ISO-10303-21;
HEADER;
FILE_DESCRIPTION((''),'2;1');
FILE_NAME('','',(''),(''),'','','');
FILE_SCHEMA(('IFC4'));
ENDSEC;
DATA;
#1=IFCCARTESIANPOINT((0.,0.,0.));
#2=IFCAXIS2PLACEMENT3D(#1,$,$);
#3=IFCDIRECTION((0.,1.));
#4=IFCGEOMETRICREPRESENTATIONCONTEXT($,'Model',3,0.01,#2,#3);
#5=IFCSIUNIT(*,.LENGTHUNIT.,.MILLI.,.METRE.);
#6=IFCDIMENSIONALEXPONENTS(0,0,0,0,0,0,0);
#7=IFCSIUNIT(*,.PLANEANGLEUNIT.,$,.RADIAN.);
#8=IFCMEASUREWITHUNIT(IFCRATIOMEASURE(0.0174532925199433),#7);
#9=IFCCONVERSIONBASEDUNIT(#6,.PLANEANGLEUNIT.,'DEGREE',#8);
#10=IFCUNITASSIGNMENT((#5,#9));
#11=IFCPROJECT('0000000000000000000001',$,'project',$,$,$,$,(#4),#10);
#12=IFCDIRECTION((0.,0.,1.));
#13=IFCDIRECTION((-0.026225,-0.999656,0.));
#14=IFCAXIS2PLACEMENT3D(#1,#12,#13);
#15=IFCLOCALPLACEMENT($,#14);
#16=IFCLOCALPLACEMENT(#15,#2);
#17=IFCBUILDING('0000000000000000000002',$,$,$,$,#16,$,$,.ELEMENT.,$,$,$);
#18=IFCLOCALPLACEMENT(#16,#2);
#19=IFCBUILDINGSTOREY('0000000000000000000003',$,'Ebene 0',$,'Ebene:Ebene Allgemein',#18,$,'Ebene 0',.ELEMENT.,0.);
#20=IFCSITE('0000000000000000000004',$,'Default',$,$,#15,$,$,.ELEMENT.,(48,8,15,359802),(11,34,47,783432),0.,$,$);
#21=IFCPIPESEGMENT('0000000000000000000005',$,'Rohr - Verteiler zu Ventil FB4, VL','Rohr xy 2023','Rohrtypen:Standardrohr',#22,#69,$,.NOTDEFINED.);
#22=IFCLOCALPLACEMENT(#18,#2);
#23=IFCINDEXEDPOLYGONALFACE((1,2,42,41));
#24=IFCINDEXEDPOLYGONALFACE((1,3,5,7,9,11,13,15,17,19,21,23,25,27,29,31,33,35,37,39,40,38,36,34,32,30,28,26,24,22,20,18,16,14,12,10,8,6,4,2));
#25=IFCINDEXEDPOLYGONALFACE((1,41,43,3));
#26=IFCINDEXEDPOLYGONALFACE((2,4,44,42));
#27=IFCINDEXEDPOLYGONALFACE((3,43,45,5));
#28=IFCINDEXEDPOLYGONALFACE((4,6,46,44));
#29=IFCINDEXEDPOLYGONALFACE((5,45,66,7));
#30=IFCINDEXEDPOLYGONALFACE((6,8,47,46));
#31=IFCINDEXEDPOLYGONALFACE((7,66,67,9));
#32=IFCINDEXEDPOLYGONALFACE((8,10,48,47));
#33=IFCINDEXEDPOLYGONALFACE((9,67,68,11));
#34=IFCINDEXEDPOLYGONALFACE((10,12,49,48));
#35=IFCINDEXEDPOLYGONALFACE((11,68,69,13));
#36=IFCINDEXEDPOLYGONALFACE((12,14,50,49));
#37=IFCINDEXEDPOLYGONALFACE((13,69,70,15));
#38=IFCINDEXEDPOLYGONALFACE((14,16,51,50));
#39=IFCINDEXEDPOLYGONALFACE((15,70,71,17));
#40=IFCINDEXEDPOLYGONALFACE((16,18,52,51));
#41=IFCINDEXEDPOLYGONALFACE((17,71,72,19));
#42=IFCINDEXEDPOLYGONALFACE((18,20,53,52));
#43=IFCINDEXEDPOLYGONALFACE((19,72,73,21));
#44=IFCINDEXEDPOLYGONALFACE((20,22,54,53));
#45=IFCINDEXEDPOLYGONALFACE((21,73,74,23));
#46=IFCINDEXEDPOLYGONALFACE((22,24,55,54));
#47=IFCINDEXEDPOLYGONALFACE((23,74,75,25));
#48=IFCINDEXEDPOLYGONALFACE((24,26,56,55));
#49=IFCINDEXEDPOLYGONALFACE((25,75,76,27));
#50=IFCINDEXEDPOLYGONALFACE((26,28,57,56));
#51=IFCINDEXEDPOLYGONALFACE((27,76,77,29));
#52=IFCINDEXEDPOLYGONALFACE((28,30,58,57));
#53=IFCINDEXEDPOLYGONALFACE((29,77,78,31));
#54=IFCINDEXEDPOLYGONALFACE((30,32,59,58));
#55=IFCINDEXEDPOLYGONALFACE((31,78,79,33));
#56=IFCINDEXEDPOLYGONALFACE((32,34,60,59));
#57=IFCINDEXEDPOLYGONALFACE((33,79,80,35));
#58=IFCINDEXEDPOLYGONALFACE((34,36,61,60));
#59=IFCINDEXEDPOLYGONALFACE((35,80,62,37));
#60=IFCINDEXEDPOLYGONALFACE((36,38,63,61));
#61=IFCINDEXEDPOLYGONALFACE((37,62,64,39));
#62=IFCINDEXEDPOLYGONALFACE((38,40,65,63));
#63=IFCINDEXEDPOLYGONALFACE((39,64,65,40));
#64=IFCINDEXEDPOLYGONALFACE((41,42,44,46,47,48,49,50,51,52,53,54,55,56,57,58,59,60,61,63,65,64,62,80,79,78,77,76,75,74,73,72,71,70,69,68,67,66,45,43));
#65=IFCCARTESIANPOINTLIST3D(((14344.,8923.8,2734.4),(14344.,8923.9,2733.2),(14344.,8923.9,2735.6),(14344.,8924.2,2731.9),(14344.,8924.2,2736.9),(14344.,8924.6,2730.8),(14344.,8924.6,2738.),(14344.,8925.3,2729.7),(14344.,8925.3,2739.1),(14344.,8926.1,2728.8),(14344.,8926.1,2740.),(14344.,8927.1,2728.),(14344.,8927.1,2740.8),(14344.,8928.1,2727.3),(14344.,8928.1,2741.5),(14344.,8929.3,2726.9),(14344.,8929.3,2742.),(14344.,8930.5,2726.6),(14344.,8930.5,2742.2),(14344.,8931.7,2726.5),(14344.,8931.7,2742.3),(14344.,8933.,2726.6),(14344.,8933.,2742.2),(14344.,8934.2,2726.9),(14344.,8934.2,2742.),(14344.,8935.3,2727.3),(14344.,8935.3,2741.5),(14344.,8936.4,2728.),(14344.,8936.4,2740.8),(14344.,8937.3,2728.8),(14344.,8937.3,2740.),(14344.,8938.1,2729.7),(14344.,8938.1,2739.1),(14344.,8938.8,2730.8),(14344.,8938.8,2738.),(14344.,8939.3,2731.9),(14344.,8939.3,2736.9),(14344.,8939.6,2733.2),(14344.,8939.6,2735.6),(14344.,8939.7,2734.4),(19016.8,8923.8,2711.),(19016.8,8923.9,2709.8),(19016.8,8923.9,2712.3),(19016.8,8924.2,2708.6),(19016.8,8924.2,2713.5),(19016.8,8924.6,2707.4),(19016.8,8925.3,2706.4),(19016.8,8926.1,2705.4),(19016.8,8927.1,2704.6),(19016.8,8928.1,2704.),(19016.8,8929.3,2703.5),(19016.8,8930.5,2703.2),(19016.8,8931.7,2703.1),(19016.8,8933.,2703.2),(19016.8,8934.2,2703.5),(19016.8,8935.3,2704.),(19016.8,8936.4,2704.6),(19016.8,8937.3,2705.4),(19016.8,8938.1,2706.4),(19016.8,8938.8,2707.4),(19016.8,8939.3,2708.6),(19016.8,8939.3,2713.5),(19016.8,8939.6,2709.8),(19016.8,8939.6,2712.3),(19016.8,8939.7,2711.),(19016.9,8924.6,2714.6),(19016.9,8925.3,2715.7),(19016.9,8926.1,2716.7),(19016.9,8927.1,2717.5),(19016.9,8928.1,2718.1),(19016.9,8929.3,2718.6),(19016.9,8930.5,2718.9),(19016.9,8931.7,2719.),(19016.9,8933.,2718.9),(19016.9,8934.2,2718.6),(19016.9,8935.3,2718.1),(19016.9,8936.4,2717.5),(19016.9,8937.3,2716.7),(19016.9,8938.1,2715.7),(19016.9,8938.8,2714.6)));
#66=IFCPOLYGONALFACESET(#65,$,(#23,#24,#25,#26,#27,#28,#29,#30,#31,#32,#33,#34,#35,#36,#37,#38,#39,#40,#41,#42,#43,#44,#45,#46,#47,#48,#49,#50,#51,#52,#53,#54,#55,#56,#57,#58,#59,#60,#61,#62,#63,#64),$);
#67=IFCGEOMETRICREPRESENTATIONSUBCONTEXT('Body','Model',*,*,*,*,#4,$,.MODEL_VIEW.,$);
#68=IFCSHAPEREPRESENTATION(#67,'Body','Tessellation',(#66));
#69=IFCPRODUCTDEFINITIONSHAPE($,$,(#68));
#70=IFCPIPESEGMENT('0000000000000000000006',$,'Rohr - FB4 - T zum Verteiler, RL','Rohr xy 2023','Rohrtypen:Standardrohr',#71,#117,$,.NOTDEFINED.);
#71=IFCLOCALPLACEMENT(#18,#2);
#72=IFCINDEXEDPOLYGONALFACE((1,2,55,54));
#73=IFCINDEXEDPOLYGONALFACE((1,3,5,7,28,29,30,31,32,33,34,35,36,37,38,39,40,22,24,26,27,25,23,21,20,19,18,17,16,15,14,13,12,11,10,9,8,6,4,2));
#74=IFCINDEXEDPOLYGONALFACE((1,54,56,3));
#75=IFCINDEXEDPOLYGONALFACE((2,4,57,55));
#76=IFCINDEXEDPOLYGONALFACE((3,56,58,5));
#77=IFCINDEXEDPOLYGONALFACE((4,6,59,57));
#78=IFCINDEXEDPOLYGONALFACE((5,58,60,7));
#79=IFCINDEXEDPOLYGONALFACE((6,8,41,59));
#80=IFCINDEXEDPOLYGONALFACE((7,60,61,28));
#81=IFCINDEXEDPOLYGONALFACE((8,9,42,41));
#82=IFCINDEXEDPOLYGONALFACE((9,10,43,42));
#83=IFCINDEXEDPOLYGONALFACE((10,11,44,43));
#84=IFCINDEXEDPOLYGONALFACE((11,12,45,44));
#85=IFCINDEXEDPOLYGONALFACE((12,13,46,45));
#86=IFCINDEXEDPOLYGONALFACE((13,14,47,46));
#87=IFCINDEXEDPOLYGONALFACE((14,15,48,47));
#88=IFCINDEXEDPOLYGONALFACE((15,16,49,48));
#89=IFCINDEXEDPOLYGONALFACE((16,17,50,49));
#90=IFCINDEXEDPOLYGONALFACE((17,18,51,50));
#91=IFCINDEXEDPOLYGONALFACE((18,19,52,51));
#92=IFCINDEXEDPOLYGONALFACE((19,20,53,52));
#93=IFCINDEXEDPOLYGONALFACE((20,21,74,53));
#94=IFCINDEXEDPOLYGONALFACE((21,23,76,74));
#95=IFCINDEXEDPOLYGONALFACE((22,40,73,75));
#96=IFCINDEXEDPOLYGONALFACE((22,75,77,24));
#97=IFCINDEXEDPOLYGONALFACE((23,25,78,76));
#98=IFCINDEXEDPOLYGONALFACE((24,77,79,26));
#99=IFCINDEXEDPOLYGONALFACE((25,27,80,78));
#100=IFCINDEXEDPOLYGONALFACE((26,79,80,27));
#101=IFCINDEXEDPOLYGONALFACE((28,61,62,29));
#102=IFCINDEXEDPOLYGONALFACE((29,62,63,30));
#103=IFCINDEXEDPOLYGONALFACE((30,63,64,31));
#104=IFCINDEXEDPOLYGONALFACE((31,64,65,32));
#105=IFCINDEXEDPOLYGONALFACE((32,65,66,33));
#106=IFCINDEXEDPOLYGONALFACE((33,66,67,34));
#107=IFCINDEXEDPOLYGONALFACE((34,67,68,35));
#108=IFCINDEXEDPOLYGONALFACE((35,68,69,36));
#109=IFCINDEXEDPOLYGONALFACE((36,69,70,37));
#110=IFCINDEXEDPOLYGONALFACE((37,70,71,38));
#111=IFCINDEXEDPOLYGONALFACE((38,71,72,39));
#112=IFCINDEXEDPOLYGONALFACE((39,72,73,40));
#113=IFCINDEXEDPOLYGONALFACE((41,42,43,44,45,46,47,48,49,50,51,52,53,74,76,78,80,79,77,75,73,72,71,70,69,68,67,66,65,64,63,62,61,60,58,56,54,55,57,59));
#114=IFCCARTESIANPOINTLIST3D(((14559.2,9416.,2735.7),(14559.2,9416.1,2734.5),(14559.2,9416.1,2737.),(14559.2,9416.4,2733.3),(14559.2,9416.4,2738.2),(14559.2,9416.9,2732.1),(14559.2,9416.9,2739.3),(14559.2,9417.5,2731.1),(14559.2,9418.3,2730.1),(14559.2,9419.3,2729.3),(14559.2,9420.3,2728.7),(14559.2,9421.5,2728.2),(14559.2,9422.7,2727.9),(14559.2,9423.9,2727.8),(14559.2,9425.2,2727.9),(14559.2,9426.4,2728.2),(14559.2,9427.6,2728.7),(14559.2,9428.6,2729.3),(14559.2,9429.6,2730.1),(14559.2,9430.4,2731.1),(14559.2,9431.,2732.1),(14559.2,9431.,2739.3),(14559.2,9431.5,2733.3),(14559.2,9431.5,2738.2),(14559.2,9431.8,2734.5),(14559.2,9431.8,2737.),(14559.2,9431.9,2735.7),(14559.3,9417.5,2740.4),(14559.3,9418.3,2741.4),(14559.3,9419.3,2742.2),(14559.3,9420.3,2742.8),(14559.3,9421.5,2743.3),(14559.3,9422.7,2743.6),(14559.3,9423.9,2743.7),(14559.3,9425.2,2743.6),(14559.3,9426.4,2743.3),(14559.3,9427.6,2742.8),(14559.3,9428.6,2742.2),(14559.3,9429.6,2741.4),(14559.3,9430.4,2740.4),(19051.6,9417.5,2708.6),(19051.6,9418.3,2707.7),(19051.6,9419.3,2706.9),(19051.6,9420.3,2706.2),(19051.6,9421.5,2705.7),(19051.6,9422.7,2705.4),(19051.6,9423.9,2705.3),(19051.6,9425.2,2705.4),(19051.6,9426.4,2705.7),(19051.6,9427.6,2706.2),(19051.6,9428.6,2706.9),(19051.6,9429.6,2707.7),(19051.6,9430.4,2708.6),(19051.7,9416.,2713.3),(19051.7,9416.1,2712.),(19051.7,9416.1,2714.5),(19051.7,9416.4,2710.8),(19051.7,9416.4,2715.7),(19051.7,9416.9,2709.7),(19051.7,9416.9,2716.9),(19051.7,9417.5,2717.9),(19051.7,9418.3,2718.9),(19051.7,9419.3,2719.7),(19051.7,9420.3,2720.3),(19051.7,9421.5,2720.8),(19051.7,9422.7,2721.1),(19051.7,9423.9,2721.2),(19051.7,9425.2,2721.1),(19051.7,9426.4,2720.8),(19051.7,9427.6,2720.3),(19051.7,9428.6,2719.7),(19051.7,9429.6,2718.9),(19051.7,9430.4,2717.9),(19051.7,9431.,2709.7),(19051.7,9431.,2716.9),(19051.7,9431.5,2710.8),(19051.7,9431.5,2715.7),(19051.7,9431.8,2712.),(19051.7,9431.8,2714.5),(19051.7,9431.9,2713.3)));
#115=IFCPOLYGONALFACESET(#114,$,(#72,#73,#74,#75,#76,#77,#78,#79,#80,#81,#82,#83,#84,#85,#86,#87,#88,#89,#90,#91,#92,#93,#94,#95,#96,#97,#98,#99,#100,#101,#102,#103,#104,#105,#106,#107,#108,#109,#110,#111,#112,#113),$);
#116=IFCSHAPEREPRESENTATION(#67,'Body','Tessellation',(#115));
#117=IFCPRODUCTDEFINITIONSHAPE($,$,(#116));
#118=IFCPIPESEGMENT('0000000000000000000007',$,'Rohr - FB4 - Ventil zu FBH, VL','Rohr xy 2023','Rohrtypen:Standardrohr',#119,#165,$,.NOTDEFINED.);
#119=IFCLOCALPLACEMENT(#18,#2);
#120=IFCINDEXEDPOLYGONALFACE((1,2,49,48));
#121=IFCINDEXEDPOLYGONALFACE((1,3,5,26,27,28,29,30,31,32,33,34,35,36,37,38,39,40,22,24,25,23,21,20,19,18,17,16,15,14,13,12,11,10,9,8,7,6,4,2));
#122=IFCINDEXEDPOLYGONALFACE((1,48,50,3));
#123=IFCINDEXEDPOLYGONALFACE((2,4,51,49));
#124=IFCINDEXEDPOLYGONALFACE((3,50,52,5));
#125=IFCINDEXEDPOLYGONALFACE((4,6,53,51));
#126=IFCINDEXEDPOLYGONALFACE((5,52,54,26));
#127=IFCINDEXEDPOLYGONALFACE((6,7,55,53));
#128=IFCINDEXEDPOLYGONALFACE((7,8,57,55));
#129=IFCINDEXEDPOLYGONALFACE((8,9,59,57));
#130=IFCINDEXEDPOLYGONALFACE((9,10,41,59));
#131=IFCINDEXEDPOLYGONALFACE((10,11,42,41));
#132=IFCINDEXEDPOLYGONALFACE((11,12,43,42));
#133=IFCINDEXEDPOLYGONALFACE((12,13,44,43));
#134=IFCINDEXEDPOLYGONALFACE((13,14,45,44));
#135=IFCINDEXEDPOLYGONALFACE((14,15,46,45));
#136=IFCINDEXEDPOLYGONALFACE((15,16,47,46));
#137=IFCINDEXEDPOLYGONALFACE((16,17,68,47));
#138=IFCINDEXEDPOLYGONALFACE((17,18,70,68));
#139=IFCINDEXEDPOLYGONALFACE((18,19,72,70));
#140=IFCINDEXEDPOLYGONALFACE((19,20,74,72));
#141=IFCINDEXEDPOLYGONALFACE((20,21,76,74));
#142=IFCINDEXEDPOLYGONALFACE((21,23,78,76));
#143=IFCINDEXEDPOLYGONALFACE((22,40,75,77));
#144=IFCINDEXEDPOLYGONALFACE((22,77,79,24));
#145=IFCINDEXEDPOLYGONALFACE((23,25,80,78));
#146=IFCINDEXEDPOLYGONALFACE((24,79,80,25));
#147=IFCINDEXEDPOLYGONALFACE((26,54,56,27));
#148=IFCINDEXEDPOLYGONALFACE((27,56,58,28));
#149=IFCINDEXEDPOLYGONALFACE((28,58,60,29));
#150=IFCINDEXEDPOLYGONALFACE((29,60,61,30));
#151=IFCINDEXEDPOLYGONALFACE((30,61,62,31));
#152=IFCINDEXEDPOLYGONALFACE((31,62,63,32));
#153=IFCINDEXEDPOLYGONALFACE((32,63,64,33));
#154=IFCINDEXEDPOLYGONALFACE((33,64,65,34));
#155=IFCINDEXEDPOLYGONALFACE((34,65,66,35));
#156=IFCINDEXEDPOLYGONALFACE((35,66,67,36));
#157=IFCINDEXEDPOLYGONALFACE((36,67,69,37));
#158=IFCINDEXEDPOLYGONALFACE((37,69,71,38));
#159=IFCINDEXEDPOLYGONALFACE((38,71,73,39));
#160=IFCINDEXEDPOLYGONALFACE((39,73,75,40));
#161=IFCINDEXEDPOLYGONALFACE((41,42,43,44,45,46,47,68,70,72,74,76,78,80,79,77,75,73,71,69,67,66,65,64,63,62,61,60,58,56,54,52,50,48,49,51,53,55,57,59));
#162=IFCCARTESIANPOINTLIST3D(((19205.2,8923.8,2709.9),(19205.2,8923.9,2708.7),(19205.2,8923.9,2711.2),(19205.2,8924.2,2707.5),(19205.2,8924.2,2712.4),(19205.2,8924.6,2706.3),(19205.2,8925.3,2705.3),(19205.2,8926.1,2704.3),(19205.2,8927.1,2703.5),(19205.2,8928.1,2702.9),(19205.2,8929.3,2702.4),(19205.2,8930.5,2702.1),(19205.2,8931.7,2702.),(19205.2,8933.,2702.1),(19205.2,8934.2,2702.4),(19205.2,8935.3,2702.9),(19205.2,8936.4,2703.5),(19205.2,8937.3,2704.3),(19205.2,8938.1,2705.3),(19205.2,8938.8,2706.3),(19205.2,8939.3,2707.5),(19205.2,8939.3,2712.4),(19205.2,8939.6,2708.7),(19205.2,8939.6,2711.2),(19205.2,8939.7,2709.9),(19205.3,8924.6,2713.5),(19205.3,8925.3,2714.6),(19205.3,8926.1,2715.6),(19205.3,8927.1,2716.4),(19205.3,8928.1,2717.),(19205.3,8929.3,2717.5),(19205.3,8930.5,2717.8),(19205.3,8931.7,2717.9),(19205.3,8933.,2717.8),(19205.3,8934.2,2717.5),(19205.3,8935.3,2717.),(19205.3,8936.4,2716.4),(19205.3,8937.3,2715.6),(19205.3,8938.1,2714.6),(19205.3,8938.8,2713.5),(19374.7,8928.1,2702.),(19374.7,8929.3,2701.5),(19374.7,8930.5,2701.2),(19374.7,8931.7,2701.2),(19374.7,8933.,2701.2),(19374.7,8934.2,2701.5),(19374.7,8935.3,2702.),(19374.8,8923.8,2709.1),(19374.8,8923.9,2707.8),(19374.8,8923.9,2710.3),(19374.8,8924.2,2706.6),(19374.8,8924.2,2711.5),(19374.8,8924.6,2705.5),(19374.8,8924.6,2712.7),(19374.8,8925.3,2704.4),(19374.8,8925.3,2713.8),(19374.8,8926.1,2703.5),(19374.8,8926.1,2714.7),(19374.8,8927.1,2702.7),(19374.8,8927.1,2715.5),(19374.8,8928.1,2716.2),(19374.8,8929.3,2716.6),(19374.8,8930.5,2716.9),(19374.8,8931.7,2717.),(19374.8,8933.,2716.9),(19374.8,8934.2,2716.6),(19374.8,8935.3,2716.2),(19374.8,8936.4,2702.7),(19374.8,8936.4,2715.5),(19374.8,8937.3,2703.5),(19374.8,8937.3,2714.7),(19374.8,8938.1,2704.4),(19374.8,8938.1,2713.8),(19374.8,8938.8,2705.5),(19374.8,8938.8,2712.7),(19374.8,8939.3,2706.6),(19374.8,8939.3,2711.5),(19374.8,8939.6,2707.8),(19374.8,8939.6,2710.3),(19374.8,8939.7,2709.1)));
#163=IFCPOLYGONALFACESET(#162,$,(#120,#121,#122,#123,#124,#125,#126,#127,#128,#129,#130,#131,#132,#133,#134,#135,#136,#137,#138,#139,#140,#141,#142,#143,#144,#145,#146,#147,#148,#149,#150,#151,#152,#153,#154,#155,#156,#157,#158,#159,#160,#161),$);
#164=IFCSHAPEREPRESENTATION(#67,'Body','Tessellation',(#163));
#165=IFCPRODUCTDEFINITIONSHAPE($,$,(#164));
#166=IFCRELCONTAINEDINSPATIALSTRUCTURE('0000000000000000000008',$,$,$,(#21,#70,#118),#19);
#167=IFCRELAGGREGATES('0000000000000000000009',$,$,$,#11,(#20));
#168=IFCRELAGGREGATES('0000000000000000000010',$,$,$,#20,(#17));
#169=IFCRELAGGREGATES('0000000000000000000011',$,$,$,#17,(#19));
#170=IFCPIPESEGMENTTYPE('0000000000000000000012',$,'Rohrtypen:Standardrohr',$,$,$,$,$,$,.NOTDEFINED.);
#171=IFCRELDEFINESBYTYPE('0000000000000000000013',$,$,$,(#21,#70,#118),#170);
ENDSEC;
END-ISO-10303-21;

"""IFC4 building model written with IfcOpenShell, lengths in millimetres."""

from ifc_helpers import new_model, entity, si_unit, converted_unit, direction, frame, origin, place, context, subcontext, project, spatial, indexed_curve, outline, extrude, type_object, element, save


model = new_model("IFC4")

# Units and contexts
model_context = context("Model", 3, precision=0.01, world=origin(), true_north=direction((0.0, 1.0)))
body_context = subcontext(model_context, "Body", "Model", "MODEL_VIEW")
ifc_project = project(units=[si_unit("LENGTHUNIT", "METRE", prefix="MILLI"), converted_unit("PLANEANGLEUNIT", "DEGREE", entity("IfcRatioMeasure", 0.0174532925199433), si_unit("PLANEANGLEUNIT", "RADIAN"), dimensions=[0, 0, 0, 0, 0, 0, 0])], contexts=[model_context])

# Site, building, storey
site_placement = place(None, frame((0.0, 0.0, 0.0), z_axis=(0.0, 0.0, 1.0), x_axis=(-0.026225, -0.999656, 0.0)))
site = spatial("IfcSite", under=ifc_project, at=site_placement, Name="Default", CompositionType="ELEMENT", RefLatitude=(48, 8, 15, 359802), RefLongitude=(11, 34, 47, 783432), RefElevation=0.0)
building_placement = place(site_placement, origin())
building = spatial("IfcBuilding", under=site, at=building_placement, CompositionType="ELEMENT")
storey_placement = place(building_placement, origin())
storey = spatial("IfcBuildingStorey", under=building, at=storey_placement, Name="Ebene 0", ObjectType="Ebene:Ebene Allgemein", LongName="Ebene 0", CompositionType="ELEMENT", Elevation=0.0)

# Pipe segments
pipe_segment_type = type_object("IfcPipeSegmentType", Name="Rohrtypen:Standardrohr", PredefinedType="NOTDEFINED")
pipe_segment_1_placement = place(storey_placement, origin())
element("IfcPipeSegment", 1, at=pipe_segment_1_placement, inside=storey, type_object=pipe_segment_type, Name="Rohr - Verteiler zu Ventil FB4, VL", Description="Rohr xy 2023", ObjectType="Rohrtypen:Standardrohr", PredefinedType="NOTDEFINED", context=body_context, shape_type="SweptSolid", body=[
    extrude(outline(indexed_curve([(7.9, 0.0), (7.8, 1.2), (7.6, 2.5), (7.1, 3.6), (6.4, 4.7), (5.6, 5.6), (4.7, 6.4), (3.6, 7.1), (2.5, 7.6), (1.2, 7.8), (0.0, 7.9), (-1.2, 7.8), (-2.5, 7.6), (-3.6, 7.1), (-4.7, 6.4), (-5.6, 5.6), (-6.4, 4.7), (-7.1, 3.6), (-7.6, 2.5), (-7.8, 1.2), (-7.9, 0.0), (-7.8, -1.2), (-7.6, -2.5), (-7.1, -3.6), (-6.4, -4.7), (-5.6, -5.6), (-4.7, -6.4), (-3.6, -7.1), (-2.5, -7.6), (-1.2, -7.8), (0.0, -7.9), (1.2, -7.8), (2.5, -7.6), (3.6, -7.1), (4.7, -6.4), (5.6, -5.6), (6.4, -4.7), (7.1, -3.6), (7.6, -2.5), (7.8, -1.2), (7.9, 0.0)], self_intersect=False)), frame((19016.8, 8931.7, 2711.0), z_axis=(-0.999988, 0.0, 0.005), x_axis=(0.0, 1.0, 0.0)), (0.0, 0.0, 1.0), 4672.9),
])
pipe_segment_2_placement = place(storey_placement, origin())
element("IfcPipeSegment", 2, at=pipe_segment_2_placement, inside=storey, type_object=pipe_segment_type, Name="Rohr - FB4 - T zum Verteiler, RL", Description="Rohr xy 2023", ObjectType="Rohrtypen:Standardrohr", PredefinedType="NOTDEFINED", context=body_context, shape_type="SweptSolid", body=[
    extrude(outline(indexed_curve([(7.9, 0.0), (7.8, 1.2), (7.6, 2.5), (7.1, 3.6), (6.4, 4.7), (5.6, 5.6), (4.7, 6.4), (3.6, 7.1), (2.5, 7.6), (1.2, 7.8), (0.0, 7.9), (-1.2, 7.8), (-2.5, 7.6), (-3.6, 7.1), (-4.7, 6.4), (-5.6, 5.6), (-6.4, 4.7), (-7.1, 3.6), (-7.6, 2.5), (-7.8, 1.2), (-7.9, 0.0), (-7.8, -1.2), (-7.6, -2.5), (-7.1, -3.6), (-6.4, -4.7), (-5.6, -5.6), (-4.7, -6.4), (-3.6, -7.1), (-2.5, -7.6), (-1.2, -7.8), (0.0, -7.9), (1.2, -7.8), (2.5, -7.6), (3.6, -7.1), (4.7, -6.4), (5.6, -5.6), (6.4, -4.7), (7.1, -3.6), (7.6, -2.5), (7.8, -1.2), (7.9, 0.0)], self_intersect=False)), frame((14559.2, 9423.9, 2735.7), z_axis=(0.999988, 0.0, -0.005), x_axis=(0.0, 1.0, 0.0)), (0.0, 0.0, 1.0), 4492.5),
])
pipe_segment_3_placement = place(storey_placement, origin())
element("IfcPipeSegment", 3, at=pipe_segment_3_placement, inside=storey, type_object=pipe_segment_type, Name="Rohr - FB4 - Ventil zu FBH, VL", Description="Rohr xy 2023", ObjectType="Rohrtypen:Standardrohr", PredefinedType="NOTDEFINED", context=body_context, shape_type="SweptSolid", body=[
    extrude(outline(indexed_curve([(7.9, 0.0), (7.8, 1.2), (7.6, 2.5), (7.1, 3.6), (6.4, 4.7), (5.6, 5.6), (4.7, 6.4), (3.6, 7.1), (2.5, 7.6), (1.2, 7.8), (0.0, 7.9), (-1.2, 7.8), (-2.5, 7.6), (-3.6, 7.1), (-4.7, 6.4), (-5.6, 5.6), (-6.4, 4.7), (-7.1, 3.6), (-7.6, 2.5), (-7.8, 1.2), (-7.9, 0.0), (-7.8, -1.2), (-7.6, -2.5), (-7.1, -3.6), (-6.4, -4.7), (-5.6, -5.6), (-4.7, -6.4), (-3.6, -7.1), (-2.5, -7.6), (-1.2, -7.8), (0.0, -7.9), (1.2, -7.8), (2.5, -7.6), (3.6, -7.1), (4.7, -6.4), (5.6, -5.6), (6.4, -4.7), (7.1, -3.6), (7.6, -2.5), (7.8, -1.2), (7.9, 0.0)], self_intersect=False)), frame((19205.2, 8931.7, 2709.9), z_axis=(0.999988, 0.0, -0.005), x_axis=(0.0, 1.0, 0.0)), (0.0, 0.0, 1.0), 169.5),
])

save(model, "model.ifc")
